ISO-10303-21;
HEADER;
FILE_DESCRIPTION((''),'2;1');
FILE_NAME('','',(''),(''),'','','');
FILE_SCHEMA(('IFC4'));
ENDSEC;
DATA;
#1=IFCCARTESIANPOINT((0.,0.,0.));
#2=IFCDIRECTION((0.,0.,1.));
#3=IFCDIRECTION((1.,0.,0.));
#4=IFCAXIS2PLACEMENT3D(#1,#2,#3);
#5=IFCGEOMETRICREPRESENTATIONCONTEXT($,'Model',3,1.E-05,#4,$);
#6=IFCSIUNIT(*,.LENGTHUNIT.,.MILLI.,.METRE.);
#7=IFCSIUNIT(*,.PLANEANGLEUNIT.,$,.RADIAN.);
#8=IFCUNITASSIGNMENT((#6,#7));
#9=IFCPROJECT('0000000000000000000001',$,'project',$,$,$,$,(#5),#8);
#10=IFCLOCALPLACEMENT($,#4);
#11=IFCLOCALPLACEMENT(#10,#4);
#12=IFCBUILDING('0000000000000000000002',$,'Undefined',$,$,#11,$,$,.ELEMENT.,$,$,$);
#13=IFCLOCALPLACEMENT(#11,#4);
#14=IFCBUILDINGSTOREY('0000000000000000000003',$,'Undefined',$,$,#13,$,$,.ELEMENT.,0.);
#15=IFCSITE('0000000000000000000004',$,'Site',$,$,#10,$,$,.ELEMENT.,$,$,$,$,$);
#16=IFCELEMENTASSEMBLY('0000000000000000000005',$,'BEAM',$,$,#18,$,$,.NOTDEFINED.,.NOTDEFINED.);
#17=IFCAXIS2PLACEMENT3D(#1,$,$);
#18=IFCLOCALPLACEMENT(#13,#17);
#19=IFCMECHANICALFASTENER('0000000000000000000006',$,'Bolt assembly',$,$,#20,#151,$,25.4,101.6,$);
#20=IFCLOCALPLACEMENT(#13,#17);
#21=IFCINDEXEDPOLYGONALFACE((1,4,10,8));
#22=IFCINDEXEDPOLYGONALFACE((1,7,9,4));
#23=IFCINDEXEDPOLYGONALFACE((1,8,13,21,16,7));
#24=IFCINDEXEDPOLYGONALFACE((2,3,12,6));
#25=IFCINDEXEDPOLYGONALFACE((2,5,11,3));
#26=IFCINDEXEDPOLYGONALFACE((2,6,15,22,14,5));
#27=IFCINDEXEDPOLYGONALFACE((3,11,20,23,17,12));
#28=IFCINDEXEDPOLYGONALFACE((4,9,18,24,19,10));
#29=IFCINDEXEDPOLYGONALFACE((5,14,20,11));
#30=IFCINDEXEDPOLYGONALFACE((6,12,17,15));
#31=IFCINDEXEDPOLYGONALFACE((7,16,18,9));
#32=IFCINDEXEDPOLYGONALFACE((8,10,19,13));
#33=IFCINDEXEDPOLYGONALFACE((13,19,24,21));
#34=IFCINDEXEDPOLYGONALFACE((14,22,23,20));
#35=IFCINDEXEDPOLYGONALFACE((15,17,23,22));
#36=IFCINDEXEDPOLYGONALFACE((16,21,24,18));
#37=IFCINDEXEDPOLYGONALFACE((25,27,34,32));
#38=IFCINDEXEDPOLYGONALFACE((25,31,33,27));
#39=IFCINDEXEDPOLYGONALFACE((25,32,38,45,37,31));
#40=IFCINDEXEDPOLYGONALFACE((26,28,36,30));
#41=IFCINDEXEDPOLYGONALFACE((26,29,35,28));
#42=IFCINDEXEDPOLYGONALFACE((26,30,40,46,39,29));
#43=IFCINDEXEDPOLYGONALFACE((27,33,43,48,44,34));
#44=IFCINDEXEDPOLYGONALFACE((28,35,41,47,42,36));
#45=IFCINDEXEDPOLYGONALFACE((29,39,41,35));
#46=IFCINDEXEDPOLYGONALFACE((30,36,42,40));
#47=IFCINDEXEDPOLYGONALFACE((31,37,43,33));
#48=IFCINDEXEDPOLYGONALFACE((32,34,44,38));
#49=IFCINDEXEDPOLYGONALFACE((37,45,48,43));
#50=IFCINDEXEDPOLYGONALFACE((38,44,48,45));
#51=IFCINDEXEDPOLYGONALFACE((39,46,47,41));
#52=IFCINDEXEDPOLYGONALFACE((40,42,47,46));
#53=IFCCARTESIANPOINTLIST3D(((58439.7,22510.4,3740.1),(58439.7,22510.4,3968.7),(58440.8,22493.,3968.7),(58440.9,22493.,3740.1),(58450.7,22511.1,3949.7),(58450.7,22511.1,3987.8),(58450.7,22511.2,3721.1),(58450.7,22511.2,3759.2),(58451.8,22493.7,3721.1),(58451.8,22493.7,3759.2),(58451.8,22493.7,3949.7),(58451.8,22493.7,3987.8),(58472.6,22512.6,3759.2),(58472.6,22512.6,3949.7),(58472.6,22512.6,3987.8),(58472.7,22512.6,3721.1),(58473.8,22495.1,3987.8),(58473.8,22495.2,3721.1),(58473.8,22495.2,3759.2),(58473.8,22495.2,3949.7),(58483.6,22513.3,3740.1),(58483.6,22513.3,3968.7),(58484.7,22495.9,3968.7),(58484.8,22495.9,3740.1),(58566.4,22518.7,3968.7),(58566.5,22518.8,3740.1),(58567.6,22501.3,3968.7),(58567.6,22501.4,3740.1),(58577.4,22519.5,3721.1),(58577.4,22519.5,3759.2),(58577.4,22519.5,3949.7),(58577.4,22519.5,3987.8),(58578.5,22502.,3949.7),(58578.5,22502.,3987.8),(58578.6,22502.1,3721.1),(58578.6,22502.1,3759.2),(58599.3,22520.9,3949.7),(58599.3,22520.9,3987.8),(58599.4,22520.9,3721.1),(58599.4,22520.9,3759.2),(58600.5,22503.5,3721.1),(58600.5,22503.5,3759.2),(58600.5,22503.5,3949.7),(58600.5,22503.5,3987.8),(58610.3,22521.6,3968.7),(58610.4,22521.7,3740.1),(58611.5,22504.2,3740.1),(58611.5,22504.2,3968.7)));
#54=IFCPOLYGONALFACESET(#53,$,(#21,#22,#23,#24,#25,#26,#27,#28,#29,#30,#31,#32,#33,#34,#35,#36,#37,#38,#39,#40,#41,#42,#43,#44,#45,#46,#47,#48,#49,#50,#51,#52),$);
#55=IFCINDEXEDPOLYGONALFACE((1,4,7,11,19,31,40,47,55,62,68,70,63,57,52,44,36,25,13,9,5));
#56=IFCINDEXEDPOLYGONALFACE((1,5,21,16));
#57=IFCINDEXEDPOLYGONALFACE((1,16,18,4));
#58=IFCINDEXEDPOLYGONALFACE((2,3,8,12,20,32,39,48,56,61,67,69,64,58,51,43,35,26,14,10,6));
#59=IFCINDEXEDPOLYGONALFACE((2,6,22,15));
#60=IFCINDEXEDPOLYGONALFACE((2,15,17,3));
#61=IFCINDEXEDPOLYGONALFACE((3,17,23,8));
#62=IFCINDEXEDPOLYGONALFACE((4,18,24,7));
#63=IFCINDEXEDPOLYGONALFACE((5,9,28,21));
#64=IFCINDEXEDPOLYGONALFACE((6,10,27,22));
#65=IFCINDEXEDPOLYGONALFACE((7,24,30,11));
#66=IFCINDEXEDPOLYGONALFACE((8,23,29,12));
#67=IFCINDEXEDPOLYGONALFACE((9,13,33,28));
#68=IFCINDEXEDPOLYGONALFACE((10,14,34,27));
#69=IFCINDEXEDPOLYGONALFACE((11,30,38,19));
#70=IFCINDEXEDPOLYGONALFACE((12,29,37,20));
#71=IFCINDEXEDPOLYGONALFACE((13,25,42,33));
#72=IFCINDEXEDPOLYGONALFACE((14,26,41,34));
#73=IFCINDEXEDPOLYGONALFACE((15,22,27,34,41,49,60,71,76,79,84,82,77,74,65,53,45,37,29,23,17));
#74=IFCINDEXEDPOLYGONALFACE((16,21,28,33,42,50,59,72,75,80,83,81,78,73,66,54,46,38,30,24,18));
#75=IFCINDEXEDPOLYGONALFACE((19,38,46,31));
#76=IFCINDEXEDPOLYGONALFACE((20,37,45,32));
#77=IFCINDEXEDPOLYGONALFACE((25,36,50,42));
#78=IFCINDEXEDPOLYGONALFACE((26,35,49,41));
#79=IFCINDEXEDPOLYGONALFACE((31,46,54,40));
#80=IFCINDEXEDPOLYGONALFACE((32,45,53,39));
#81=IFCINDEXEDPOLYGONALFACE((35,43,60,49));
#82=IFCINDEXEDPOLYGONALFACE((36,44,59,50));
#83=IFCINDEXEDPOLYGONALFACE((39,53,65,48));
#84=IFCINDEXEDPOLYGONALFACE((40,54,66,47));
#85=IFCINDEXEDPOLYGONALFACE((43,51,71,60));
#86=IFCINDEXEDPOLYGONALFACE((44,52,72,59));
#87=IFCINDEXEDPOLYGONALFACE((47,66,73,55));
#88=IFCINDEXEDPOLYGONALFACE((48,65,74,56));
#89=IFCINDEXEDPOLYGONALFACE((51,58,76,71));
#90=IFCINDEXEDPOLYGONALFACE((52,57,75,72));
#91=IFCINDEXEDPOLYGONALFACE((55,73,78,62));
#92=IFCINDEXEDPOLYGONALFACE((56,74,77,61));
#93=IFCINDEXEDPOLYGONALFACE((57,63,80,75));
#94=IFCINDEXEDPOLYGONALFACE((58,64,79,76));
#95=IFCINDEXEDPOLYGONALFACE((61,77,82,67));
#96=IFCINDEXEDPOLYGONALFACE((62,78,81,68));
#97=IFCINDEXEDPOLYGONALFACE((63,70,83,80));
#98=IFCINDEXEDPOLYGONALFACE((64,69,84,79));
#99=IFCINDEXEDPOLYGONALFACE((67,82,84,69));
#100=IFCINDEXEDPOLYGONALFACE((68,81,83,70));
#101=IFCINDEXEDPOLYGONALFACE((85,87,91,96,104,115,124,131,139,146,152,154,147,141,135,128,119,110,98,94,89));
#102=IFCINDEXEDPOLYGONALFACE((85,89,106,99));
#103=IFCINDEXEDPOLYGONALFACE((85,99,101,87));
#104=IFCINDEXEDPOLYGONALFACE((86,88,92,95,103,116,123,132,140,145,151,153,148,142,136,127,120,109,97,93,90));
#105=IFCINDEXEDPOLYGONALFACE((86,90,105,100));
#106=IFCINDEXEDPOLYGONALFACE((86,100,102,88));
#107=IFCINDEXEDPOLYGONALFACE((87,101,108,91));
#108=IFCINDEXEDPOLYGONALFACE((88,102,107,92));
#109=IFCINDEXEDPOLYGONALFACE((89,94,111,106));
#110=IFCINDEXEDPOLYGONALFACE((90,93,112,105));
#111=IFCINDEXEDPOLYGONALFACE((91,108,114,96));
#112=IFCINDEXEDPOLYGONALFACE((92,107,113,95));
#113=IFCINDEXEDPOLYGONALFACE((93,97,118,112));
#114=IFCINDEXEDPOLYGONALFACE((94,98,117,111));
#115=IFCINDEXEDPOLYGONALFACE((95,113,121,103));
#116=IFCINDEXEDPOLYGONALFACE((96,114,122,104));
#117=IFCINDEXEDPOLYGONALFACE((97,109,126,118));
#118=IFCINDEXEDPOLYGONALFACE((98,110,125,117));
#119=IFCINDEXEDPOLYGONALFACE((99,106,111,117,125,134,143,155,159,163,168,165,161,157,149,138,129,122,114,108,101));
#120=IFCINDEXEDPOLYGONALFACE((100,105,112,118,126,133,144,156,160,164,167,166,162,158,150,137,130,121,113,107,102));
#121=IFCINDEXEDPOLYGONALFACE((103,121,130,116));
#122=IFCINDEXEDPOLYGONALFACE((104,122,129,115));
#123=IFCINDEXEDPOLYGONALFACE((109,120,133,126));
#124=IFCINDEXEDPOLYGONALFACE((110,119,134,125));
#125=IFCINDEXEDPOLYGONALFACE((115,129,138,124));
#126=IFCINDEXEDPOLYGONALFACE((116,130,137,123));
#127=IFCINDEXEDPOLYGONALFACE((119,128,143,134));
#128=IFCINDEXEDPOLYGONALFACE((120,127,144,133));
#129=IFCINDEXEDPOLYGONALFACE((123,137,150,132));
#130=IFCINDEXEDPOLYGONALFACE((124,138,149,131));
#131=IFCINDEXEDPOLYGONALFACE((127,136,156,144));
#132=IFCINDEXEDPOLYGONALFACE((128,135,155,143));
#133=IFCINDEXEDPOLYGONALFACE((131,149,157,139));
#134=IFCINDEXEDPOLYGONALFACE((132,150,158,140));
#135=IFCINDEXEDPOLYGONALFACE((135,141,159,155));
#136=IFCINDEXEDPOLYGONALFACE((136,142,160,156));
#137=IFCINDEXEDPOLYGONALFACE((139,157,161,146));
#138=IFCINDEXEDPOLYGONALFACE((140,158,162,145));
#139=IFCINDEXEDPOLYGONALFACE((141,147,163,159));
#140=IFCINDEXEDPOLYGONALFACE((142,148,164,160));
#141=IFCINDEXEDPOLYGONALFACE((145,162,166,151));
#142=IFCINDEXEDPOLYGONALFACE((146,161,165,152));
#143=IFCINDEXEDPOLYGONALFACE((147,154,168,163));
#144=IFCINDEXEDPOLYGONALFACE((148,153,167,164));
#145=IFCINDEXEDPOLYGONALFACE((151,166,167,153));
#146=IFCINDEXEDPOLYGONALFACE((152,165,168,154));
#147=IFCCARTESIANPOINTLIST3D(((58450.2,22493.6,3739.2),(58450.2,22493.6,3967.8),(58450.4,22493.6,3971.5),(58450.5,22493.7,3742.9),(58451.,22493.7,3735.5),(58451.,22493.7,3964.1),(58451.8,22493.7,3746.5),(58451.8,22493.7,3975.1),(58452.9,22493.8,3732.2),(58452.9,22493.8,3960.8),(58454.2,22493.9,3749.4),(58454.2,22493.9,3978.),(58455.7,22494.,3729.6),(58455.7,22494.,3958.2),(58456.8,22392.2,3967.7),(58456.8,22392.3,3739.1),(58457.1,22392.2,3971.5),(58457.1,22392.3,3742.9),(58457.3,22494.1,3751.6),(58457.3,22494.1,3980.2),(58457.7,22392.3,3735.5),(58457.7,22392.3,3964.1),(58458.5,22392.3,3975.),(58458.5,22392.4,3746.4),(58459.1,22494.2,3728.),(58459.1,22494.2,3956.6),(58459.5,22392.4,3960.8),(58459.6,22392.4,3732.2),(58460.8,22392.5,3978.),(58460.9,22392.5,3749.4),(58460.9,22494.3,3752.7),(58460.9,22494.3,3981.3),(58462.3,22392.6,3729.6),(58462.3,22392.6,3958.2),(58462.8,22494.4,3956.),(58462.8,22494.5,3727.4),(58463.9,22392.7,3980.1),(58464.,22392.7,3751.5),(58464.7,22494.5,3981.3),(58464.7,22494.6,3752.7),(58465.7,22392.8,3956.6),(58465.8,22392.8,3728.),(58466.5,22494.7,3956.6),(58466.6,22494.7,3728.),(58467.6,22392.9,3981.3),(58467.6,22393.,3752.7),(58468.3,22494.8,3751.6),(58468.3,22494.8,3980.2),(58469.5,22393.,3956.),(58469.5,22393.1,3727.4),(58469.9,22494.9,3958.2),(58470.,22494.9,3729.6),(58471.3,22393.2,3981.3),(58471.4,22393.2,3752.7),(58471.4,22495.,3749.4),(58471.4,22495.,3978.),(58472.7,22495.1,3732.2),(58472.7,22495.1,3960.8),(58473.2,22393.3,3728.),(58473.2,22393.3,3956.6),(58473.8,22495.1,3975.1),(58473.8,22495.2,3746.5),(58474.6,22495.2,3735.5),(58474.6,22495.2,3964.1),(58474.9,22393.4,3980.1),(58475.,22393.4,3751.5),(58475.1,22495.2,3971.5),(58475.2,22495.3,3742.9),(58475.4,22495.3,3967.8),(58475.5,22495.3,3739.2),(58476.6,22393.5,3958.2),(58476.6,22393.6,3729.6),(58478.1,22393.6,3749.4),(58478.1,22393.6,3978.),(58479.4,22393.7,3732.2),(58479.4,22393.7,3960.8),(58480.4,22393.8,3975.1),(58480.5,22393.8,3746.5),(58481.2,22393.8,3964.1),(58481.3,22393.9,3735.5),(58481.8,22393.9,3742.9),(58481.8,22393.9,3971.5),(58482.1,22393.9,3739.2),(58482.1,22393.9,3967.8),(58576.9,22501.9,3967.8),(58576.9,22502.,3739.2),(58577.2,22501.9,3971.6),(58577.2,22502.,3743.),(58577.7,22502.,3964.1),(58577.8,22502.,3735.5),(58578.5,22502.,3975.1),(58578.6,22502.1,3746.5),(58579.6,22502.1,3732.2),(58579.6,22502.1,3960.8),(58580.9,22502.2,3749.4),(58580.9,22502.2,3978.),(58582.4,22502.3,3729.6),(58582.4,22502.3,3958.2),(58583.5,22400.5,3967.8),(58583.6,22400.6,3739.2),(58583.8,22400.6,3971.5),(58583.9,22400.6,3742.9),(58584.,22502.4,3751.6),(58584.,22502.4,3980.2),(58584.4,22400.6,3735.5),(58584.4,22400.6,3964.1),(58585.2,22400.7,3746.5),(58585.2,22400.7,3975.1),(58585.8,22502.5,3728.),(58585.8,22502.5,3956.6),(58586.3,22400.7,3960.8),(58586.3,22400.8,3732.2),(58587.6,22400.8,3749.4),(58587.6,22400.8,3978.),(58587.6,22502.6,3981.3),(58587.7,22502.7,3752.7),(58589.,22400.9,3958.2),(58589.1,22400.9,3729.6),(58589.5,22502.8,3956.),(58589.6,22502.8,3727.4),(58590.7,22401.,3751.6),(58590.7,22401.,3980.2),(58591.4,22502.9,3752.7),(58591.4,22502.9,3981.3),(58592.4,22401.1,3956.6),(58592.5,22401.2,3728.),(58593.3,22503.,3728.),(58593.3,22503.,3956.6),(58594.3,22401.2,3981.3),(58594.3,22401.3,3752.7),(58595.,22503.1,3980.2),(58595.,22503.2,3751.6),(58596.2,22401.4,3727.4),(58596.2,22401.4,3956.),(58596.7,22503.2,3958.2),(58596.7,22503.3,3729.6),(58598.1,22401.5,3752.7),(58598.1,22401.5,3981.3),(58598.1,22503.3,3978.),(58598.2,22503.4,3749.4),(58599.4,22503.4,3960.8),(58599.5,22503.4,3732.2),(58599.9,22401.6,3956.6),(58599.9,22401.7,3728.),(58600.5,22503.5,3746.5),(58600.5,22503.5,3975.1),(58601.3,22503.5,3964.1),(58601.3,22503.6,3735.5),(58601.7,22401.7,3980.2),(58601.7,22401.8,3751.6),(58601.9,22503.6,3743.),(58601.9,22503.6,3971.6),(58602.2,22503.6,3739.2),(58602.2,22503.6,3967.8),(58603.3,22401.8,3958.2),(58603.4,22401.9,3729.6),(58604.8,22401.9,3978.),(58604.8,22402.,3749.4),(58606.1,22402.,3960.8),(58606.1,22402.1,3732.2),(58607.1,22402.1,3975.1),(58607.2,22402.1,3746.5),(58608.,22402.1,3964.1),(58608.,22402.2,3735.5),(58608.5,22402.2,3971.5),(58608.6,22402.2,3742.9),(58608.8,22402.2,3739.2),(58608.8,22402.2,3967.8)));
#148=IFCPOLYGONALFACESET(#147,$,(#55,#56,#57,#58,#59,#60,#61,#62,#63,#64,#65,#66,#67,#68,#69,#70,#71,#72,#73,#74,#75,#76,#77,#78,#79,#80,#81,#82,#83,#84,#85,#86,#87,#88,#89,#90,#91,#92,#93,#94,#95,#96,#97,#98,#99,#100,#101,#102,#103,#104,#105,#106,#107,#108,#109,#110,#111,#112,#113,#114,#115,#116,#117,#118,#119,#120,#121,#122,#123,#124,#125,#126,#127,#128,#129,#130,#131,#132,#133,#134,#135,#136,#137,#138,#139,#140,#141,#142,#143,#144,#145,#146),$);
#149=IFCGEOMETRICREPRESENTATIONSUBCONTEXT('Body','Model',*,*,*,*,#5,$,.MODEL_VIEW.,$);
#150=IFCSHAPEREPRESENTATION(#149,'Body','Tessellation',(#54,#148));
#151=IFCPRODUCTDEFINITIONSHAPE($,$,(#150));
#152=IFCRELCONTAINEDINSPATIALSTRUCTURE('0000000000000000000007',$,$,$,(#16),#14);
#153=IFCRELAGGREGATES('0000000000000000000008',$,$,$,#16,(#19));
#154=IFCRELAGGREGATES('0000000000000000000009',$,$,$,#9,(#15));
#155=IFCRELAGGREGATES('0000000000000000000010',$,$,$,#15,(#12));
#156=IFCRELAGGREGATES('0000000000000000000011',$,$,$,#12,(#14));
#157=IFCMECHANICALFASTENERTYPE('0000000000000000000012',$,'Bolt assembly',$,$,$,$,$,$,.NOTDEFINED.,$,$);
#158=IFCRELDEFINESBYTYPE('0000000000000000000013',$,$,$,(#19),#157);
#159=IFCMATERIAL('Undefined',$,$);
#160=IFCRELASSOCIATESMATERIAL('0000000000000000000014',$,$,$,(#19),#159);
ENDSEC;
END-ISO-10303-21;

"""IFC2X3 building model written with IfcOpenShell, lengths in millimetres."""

from ifc_helpers import new_model, si_unit, frame, origin_with_axes, origin_2d_with_axis, place, context, subcontext, project, spatial, polyline, circle, outline, extrude, source, transform, mapped, material, type_object, element, aggregate, save


model = new_model("IFC2X3")

# Units and contexts
model_context = context("Model", 3, precision=1e-05, world=origin_with_axes())
body_context = subcontext(model_context, "Body", "Model", "MODEL_VIEW")
ifc_project = project(units=[si_unit("LENGTHUNIT", "METRE", prefix="MILLI"), si_unit("PLANEANGLEUNIT", "RADIAN")], contexts=[model_context])

# Site, building, storey
site_placement = place(None, origin_with_axes())
site = spatial("IfcSite", under=ifc_project, at=site_placement, Name="Site", CompositionType="ELEMENT")
building_placement = place(site_placement, origin_with_axes())
building = spatial("IfcBuilding", under=site, at=building_placement, Name="Undefined", CompositionType="ELEMENT")
storey_placement = place(building_placement, origin_with_axes())
storey = spatial("IfcBuildingStorey", under=building, at=storey_placement, Name="Undefined", CompositionType="ELEMENT", Elevation=0.0)

# Element assembly
assembly_1_placement = place(storey_placement, origin_with_axes())
assembly_1 = element("IfcElementAssembly", 1, at=assembly_1_placement, inside=storey, Name="BEAM", AssemblyPlace="NOTDEFINED", PredefinedType="NOTDEFINED")

# Mechanical fastener
ifc_material_1 = material(Name="Undefined")
mechanical_fastener_type = type_object("IfcMechanicalFastenerType", Name="Bolt assembly")
shared_shape_1 = source(origin_with_axes(), body_context, "Body", "SweptSolid", [
    extrude(outline(polyline([(19.0, -11.0), (19.0, 11.0), (0.0, 22.0), (-19.0, 11.0), (-19.0, -11.0), (0.0, -22.0), (19.0, -11.0)])), frame((0.0, -17.5, 0.0), z_axis=(0.0, 1.0, 0.0), x_axis=(1.0, 0.0, 0.0)), (0.0, 0.0, 1.0), 17.5),
    extrude(circle(Radius=12.7, at=origin_2d_with_axis()), frame((0.0, 0.0, 0.0), z_axis=(0.0, 1.0, 0.0), x_axis=(1.0, 0.0, 0.0)), (0.0, 0.0, 1.0), 101.6),
])
mechanical_fastener_1_placement = place(assembly_1_placement, frame((58526.2, 22498.6, 3968.7), z_axis=(-0.997848, -0.065571, -0.000163), x_axis=(0.000152, 0.000169, -1.0)))
mechanical_fastener_1 = element("IfcMechanicalFastener", 2, at=mechanical_fastener_1_placement, type_object=mechanical_fastener_type, material=ifc_material_1, Name="Bolt assembly", NominalDiameter=25.4, NominalLength=101.6, context=body_context, shape_type="MappedRepresentation", body=[
    mapped(shared_shape_1, transform((0.0, 0.0, -63.5))),
    mapped(shared_shape_1, transform((228.6, 0.0, -63.5))),
    mapped(shared_shape_1, transform((0.0, 0.0, 63.5))),
    mapped(shared_shape_1, transform((228.6, 0.0, 63.5))),
])
aggregate(assembly_1, [mechanical_fastener_1])

save(model, "model.ifc")
